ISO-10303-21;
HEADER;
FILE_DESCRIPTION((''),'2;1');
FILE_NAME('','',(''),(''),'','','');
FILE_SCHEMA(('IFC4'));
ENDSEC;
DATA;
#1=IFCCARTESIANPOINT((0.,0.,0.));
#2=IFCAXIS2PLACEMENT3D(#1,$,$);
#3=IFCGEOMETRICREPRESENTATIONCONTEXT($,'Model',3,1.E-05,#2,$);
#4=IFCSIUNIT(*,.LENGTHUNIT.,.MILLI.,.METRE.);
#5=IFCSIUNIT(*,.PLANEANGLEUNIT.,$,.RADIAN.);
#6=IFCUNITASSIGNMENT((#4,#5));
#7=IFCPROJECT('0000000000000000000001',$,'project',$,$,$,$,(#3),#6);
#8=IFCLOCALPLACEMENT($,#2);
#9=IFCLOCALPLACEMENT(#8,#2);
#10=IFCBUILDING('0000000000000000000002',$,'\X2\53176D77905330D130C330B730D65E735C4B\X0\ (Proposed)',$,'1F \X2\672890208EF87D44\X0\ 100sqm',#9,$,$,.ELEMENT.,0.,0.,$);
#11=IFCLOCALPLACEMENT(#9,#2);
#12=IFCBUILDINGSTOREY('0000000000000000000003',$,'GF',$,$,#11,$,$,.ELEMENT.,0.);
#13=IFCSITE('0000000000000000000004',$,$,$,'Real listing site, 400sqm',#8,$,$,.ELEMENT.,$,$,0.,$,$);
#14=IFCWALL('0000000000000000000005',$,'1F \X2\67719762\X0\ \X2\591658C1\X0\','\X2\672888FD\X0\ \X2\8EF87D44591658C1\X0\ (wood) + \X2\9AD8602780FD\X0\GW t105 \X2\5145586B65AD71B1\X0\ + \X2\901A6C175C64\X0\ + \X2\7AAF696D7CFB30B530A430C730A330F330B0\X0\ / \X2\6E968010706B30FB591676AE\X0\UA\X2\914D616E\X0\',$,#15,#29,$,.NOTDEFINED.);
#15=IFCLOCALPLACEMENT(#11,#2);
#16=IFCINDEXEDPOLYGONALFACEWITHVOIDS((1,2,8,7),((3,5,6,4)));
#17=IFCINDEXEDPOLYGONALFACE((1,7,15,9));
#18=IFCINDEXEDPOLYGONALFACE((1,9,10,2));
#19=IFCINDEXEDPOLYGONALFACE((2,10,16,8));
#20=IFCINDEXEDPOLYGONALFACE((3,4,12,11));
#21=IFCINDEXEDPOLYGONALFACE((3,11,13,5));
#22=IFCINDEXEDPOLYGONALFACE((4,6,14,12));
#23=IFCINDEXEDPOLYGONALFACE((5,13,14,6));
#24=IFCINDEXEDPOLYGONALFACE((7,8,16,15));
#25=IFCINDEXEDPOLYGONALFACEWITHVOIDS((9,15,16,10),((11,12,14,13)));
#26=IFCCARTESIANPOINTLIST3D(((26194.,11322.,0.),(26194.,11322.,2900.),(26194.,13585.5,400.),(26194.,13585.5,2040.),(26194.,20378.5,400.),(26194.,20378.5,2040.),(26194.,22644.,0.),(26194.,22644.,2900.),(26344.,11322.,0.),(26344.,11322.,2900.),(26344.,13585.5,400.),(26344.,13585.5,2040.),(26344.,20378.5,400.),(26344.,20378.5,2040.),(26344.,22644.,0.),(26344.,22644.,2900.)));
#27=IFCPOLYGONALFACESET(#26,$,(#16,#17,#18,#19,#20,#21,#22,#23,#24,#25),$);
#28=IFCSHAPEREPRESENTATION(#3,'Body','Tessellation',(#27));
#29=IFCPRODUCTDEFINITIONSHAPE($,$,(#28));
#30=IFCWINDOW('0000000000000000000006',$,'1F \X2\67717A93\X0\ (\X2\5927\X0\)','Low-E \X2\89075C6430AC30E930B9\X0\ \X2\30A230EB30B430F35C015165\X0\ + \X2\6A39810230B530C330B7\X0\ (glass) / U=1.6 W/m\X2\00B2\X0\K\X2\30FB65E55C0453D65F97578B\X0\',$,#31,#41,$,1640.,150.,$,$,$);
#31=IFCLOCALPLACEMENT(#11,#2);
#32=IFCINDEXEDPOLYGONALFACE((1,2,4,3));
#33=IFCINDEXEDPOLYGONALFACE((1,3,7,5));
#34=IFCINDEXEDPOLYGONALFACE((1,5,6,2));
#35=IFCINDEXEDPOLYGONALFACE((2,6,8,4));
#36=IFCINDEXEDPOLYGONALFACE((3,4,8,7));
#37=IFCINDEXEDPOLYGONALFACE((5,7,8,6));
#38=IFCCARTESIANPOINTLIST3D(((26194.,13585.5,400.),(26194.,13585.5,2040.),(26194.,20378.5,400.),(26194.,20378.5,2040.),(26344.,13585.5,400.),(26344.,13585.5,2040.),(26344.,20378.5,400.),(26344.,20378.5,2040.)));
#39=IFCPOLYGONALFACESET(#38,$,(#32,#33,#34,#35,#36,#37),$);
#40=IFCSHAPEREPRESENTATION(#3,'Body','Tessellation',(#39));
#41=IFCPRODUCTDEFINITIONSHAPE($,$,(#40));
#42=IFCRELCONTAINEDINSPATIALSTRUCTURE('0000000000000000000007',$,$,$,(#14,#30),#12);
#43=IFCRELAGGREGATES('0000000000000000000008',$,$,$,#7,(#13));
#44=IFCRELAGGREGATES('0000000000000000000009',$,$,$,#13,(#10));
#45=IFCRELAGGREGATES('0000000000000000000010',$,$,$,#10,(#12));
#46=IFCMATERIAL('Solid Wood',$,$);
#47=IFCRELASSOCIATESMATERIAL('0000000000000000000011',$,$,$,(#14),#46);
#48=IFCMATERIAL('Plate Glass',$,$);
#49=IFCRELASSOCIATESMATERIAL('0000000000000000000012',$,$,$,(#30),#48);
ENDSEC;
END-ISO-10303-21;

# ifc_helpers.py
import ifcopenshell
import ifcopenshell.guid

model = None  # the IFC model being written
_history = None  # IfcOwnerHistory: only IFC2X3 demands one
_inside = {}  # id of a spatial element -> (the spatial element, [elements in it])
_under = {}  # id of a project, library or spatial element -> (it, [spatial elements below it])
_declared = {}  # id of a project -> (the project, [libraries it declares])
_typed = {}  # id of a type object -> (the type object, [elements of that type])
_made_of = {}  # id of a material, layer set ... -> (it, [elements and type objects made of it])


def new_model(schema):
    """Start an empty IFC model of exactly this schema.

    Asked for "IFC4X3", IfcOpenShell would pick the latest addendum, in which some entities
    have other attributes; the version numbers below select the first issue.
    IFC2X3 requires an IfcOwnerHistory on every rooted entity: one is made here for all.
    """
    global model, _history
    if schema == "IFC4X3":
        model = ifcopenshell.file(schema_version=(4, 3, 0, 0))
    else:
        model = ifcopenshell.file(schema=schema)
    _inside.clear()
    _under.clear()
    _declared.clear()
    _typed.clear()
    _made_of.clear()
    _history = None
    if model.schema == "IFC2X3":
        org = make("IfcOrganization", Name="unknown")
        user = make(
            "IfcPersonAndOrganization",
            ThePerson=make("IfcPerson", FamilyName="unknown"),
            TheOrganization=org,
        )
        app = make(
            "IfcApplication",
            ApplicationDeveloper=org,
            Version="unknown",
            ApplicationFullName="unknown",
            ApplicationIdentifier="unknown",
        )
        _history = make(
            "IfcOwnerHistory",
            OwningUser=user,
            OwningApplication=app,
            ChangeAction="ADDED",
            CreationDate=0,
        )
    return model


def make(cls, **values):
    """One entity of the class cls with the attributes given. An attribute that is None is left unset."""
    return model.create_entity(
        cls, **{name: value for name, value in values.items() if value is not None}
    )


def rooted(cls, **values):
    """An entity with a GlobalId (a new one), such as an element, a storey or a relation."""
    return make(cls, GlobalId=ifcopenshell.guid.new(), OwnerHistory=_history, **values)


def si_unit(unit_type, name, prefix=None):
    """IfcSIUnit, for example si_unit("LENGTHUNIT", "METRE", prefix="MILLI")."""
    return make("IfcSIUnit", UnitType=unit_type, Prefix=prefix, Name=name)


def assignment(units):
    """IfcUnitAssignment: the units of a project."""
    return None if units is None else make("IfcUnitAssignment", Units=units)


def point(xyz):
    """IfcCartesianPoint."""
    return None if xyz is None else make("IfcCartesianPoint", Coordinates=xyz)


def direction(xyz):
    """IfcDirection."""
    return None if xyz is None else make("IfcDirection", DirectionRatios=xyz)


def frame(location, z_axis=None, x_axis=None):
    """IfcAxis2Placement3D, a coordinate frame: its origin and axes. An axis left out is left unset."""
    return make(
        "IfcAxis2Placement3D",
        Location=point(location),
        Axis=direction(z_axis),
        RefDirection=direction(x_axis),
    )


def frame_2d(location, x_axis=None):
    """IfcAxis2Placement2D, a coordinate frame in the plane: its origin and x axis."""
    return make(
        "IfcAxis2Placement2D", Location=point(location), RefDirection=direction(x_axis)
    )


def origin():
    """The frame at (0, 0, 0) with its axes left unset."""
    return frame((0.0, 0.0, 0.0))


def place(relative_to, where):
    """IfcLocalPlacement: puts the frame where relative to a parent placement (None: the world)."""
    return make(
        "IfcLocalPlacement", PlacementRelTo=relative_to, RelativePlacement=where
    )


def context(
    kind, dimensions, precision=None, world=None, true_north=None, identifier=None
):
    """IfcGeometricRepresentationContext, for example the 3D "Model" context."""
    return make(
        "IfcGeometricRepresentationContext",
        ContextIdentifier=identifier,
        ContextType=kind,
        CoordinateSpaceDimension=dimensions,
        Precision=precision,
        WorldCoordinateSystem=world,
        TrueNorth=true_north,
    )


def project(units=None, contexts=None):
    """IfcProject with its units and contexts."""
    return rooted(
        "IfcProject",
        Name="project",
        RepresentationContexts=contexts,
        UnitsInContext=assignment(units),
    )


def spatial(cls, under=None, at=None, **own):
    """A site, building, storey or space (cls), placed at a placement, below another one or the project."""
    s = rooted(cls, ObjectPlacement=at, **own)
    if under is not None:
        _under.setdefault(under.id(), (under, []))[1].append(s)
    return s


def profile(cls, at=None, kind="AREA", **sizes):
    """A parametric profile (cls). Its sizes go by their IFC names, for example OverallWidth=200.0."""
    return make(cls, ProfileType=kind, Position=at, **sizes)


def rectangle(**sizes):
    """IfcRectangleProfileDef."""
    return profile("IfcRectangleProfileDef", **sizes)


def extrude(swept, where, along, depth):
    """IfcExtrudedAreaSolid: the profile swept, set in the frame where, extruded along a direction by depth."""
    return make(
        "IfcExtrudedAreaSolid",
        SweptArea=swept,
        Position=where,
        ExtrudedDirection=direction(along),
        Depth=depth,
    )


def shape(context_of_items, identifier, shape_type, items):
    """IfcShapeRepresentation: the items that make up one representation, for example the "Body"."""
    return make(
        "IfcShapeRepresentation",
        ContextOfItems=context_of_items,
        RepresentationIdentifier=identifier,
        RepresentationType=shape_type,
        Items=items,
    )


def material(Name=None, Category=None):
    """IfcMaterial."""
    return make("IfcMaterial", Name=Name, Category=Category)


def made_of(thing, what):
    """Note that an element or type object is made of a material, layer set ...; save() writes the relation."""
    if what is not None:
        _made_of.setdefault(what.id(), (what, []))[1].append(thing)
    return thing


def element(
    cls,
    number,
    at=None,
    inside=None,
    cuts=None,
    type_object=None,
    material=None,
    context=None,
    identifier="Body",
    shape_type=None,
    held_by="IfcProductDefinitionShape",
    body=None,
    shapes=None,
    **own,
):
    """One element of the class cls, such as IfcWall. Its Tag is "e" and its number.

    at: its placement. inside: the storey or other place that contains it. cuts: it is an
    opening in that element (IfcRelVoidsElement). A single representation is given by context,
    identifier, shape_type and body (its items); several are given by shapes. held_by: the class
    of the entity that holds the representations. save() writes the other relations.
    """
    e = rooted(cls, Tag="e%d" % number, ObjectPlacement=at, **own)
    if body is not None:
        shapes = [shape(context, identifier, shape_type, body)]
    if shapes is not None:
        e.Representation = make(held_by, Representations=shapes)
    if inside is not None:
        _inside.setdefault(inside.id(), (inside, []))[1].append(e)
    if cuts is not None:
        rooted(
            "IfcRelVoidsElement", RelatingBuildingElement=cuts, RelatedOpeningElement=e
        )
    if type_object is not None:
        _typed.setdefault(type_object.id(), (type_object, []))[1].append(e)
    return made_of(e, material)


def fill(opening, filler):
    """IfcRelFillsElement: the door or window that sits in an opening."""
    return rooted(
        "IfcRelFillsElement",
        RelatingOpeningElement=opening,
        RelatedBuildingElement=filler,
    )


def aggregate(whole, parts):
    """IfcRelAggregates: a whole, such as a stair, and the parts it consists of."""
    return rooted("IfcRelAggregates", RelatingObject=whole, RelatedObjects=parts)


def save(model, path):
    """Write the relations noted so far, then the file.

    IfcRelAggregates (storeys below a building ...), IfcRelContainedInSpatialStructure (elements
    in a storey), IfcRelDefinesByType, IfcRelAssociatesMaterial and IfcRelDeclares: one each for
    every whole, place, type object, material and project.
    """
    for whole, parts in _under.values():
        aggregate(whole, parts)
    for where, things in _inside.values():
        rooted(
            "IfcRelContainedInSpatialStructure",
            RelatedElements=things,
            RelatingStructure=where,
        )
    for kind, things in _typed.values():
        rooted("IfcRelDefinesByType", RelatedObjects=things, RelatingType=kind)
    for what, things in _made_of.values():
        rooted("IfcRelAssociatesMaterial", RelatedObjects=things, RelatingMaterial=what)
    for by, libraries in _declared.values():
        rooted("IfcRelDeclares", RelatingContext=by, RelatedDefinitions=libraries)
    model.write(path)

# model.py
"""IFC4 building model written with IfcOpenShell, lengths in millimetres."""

from ifc_helpers import new_model, si_unit, frame, frame_2d, origin, place, context, project, spatial, rectangle, extrude, material, element, fill, save


model = new_model("IFC4")

# Units and contexts
model_context = context("Model", 3, precision=1e-05, world=origin())
ifc_project = project(units=[si_unit("LENGTHUNIT", "METRE", prefix="MILLI"), si_unit("PLANEANGLEUNIT", "RADIAN")], contexts=[model_context])

# Site, building, storey
site_placement = place(None, origin())
site = spatial("IfcSite", under=ifc_project, at=site_placement, ObjectType="Real listing site, 400sqm", CompositionType="ELEMENT", RefElevation=0.0)
building_placement = place(site_placement, origin())
building = spatial("IfcBuilding", under=site, at=building_placement, Name="北海道パッシブ平屋 (Proposed)", ObjectType="1F 木造軸組 100sqm", CompositionType="ELEMENT", ElevationOfRefHeight=0.0, ElevationOfTerrain=0.0)
storey_placement = place(building_placement, origin())
storey = spatial("IfcBuildingStorey", under=building, at=storey_placement, Name="GF", CompositionType="ELEMENT", Elevation=0.0)

# Shared definitions
ifc_material_1 = material(Name="Solid Wood")

# Shared definitions
ifc_material_2 = material(Name="Plate Glass")

# Wall, opening, window
wall_1_placement = place(storey_placement, frame((13097.0, 5661.0, 0.0)))
wall_1 = element("IfcWall", 1, at=wall_1_placement, inside=storey, material=ifc_material_1, Name="1F 東面 外壁", Description="木製 軸組外壁 (wood) + 高性能GW t105 充填断熱 + 通気層 + 窯業系サイディング / 準耐火・外皮UA配慮", PredefinedType="NOTDEFINED", context=model_context, shape_type="SweptSolid", body=[
    extrude(rectangle(XDim=150.0, YDim=11322.0, at=frame_2d((75.0, 5661.0))), frame((13097.0, 5661.0, 0.0)), (0.0, 0.0, 1.0), 2900.0),
])
opening_1_placement = place(storey_placement, frame((13097.0, 6793.0, 200.0)))
opening_1 = element("IfcOpeningElement", 2, at=opening_1_placement, cuts=wall_1, PredefinedType="NOTDEFINED", context=model_context, shape_type="SweptSolid", body=[
    extrude(rectangle(XDim=150.0, YDim=6793.0, at=frame_2d((75.0, 3396.0))), frame((13097.0, 6793.0, 200.0)), (0.0, 0.0, 1.0), 1640.0),
])
window_1_placement = place(storey_placement, frame((13097.0, 6793.0, 200.0)))
window_1 = element("IfcWindow", 3, at=window_1_placement, inside=storey, material=ifc_material_2, Name="1F 東窓 (大)", Description="Low-E 複層ガラス アルゴン封入 + 樹脂サッシ (glass) / U=1.6 W/m²K・日射取得型", OverallHeight=1640.0, OverallWidth=150.0, context=model_context, shape_type="SweptSolid", body=[
    extrude(rectangle(XDim=150.0, YDim=6793.0, at=frame_2d((75.0, 3396.0))), frame((13097.0, 6793.0, 200.0)), (0.0, 0.0, 1.0), 1640.0),
])
fill(opening_1, window_1)

save(model, "model.ifc")
